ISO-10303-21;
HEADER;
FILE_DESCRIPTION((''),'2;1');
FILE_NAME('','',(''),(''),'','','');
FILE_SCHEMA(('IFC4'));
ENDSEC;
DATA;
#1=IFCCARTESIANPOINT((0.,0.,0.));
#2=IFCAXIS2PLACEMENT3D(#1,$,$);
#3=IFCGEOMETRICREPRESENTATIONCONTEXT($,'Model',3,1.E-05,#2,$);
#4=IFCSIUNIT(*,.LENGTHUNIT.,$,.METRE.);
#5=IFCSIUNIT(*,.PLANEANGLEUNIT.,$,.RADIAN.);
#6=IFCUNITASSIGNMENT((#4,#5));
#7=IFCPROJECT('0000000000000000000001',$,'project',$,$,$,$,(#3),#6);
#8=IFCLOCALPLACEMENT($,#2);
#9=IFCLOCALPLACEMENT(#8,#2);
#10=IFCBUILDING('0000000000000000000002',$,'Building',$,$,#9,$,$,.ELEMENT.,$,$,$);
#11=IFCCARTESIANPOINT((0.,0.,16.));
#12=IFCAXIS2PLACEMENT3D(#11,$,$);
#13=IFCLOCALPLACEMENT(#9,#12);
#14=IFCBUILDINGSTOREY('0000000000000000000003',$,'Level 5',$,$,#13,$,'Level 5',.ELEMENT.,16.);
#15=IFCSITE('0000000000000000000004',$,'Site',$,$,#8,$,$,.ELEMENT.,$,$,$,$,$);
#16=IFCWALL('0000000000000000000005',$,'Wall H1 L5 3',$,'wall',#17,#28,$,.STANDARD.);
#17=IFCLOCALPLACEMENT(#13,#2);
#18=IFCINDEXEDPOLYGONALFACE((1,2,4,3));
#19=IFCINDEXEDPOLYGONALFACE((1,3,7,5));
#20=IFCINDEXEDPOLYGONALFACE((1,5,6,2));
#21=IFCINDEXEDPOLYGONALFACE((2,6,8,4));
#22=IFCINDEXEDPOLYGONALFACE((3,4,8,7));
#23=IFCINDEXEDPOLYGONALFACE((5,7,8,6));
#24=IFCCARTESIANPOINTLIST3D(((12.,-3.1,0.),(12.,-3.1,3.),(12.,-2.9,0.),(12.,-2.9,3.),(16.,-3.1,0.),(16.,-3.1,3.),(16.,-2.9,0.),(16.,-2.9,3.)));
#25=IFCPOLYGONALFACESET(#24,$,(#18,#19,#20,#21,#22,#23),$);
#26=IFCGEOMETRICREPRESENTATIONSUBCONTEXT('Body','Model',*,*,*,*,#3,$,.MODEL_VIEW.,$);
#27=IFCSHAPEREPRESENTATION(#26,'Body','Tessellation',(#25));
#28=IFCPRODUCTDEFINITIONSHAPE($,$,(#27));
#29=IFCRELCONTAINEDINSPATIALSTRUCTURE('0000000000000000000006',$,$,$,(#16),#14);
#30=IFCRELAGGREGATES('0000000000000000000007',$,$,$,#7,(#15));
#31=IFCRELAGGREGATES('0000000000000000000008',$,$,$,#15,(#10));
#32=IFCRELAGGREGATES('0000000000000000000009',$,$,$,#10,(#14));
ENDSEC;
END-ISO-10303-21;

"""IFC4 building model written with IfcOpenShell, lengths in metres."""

from ifc_helpers import new_model, si_unit, frame, frame_2d, origin, place, context, subcontext, project, spatial, rectangle, extrude, element, save


model = new_model("IFC4")

# Units and contexts
model_context = context("Model", 3, precision=1e-05, world=origin())
body_context = subcontext(model_context, "Body", "Model", "MODEL_VIEW")
ifc_project = project(units=[si_unit("LENGTHUNIT", "METRE"), si_unit("PLANEANGLEUNIT", "RADIAN")], contexts=[model_context])

# Site, building, storey
site_placement = place(None, origin())
site = spatial("IfcSite", under=ifc_project, at=site_placement, Name="Site", CompositionType="ELEMENT")
building_placement = place(site_placement, origin())
building = spatial("IfcBuilding", under=site, at=building_placement, Name="Building", CompositionType="ELEMENT")
storey_placement = place(building_placement, frame((0.0, 0.0, 16.0)))
storey = spatial("IfcBuildingStorey", under=building, at=storey_placement, Name="Level 5", LongName="Level 5", CompositionType="ELEMENT", Elevation=16.0)

# Wall
wall_1_placement = place(storey_placement, frame((12.0, -3.0, 0.0), z_axis=(0.0, 0.0, 1.0), x_axis=(1.0, 0.0, 0.0)))
element("IfcWall", 1, at=wall_1_placement, inside=storey, Name="Wall H1 L5 3", ObjectType="wall", PredefinedType="STANDARD", context=body_context, shape_type="SweptSolid", body=[
    extrude(rectangle(XDim=4.0, YDim=0.2, at=frame_2d((2.0, 0.0))), origin(), (0.0, 0.0, 1.0), 3.0),
])

save(model, "model.ifc")
